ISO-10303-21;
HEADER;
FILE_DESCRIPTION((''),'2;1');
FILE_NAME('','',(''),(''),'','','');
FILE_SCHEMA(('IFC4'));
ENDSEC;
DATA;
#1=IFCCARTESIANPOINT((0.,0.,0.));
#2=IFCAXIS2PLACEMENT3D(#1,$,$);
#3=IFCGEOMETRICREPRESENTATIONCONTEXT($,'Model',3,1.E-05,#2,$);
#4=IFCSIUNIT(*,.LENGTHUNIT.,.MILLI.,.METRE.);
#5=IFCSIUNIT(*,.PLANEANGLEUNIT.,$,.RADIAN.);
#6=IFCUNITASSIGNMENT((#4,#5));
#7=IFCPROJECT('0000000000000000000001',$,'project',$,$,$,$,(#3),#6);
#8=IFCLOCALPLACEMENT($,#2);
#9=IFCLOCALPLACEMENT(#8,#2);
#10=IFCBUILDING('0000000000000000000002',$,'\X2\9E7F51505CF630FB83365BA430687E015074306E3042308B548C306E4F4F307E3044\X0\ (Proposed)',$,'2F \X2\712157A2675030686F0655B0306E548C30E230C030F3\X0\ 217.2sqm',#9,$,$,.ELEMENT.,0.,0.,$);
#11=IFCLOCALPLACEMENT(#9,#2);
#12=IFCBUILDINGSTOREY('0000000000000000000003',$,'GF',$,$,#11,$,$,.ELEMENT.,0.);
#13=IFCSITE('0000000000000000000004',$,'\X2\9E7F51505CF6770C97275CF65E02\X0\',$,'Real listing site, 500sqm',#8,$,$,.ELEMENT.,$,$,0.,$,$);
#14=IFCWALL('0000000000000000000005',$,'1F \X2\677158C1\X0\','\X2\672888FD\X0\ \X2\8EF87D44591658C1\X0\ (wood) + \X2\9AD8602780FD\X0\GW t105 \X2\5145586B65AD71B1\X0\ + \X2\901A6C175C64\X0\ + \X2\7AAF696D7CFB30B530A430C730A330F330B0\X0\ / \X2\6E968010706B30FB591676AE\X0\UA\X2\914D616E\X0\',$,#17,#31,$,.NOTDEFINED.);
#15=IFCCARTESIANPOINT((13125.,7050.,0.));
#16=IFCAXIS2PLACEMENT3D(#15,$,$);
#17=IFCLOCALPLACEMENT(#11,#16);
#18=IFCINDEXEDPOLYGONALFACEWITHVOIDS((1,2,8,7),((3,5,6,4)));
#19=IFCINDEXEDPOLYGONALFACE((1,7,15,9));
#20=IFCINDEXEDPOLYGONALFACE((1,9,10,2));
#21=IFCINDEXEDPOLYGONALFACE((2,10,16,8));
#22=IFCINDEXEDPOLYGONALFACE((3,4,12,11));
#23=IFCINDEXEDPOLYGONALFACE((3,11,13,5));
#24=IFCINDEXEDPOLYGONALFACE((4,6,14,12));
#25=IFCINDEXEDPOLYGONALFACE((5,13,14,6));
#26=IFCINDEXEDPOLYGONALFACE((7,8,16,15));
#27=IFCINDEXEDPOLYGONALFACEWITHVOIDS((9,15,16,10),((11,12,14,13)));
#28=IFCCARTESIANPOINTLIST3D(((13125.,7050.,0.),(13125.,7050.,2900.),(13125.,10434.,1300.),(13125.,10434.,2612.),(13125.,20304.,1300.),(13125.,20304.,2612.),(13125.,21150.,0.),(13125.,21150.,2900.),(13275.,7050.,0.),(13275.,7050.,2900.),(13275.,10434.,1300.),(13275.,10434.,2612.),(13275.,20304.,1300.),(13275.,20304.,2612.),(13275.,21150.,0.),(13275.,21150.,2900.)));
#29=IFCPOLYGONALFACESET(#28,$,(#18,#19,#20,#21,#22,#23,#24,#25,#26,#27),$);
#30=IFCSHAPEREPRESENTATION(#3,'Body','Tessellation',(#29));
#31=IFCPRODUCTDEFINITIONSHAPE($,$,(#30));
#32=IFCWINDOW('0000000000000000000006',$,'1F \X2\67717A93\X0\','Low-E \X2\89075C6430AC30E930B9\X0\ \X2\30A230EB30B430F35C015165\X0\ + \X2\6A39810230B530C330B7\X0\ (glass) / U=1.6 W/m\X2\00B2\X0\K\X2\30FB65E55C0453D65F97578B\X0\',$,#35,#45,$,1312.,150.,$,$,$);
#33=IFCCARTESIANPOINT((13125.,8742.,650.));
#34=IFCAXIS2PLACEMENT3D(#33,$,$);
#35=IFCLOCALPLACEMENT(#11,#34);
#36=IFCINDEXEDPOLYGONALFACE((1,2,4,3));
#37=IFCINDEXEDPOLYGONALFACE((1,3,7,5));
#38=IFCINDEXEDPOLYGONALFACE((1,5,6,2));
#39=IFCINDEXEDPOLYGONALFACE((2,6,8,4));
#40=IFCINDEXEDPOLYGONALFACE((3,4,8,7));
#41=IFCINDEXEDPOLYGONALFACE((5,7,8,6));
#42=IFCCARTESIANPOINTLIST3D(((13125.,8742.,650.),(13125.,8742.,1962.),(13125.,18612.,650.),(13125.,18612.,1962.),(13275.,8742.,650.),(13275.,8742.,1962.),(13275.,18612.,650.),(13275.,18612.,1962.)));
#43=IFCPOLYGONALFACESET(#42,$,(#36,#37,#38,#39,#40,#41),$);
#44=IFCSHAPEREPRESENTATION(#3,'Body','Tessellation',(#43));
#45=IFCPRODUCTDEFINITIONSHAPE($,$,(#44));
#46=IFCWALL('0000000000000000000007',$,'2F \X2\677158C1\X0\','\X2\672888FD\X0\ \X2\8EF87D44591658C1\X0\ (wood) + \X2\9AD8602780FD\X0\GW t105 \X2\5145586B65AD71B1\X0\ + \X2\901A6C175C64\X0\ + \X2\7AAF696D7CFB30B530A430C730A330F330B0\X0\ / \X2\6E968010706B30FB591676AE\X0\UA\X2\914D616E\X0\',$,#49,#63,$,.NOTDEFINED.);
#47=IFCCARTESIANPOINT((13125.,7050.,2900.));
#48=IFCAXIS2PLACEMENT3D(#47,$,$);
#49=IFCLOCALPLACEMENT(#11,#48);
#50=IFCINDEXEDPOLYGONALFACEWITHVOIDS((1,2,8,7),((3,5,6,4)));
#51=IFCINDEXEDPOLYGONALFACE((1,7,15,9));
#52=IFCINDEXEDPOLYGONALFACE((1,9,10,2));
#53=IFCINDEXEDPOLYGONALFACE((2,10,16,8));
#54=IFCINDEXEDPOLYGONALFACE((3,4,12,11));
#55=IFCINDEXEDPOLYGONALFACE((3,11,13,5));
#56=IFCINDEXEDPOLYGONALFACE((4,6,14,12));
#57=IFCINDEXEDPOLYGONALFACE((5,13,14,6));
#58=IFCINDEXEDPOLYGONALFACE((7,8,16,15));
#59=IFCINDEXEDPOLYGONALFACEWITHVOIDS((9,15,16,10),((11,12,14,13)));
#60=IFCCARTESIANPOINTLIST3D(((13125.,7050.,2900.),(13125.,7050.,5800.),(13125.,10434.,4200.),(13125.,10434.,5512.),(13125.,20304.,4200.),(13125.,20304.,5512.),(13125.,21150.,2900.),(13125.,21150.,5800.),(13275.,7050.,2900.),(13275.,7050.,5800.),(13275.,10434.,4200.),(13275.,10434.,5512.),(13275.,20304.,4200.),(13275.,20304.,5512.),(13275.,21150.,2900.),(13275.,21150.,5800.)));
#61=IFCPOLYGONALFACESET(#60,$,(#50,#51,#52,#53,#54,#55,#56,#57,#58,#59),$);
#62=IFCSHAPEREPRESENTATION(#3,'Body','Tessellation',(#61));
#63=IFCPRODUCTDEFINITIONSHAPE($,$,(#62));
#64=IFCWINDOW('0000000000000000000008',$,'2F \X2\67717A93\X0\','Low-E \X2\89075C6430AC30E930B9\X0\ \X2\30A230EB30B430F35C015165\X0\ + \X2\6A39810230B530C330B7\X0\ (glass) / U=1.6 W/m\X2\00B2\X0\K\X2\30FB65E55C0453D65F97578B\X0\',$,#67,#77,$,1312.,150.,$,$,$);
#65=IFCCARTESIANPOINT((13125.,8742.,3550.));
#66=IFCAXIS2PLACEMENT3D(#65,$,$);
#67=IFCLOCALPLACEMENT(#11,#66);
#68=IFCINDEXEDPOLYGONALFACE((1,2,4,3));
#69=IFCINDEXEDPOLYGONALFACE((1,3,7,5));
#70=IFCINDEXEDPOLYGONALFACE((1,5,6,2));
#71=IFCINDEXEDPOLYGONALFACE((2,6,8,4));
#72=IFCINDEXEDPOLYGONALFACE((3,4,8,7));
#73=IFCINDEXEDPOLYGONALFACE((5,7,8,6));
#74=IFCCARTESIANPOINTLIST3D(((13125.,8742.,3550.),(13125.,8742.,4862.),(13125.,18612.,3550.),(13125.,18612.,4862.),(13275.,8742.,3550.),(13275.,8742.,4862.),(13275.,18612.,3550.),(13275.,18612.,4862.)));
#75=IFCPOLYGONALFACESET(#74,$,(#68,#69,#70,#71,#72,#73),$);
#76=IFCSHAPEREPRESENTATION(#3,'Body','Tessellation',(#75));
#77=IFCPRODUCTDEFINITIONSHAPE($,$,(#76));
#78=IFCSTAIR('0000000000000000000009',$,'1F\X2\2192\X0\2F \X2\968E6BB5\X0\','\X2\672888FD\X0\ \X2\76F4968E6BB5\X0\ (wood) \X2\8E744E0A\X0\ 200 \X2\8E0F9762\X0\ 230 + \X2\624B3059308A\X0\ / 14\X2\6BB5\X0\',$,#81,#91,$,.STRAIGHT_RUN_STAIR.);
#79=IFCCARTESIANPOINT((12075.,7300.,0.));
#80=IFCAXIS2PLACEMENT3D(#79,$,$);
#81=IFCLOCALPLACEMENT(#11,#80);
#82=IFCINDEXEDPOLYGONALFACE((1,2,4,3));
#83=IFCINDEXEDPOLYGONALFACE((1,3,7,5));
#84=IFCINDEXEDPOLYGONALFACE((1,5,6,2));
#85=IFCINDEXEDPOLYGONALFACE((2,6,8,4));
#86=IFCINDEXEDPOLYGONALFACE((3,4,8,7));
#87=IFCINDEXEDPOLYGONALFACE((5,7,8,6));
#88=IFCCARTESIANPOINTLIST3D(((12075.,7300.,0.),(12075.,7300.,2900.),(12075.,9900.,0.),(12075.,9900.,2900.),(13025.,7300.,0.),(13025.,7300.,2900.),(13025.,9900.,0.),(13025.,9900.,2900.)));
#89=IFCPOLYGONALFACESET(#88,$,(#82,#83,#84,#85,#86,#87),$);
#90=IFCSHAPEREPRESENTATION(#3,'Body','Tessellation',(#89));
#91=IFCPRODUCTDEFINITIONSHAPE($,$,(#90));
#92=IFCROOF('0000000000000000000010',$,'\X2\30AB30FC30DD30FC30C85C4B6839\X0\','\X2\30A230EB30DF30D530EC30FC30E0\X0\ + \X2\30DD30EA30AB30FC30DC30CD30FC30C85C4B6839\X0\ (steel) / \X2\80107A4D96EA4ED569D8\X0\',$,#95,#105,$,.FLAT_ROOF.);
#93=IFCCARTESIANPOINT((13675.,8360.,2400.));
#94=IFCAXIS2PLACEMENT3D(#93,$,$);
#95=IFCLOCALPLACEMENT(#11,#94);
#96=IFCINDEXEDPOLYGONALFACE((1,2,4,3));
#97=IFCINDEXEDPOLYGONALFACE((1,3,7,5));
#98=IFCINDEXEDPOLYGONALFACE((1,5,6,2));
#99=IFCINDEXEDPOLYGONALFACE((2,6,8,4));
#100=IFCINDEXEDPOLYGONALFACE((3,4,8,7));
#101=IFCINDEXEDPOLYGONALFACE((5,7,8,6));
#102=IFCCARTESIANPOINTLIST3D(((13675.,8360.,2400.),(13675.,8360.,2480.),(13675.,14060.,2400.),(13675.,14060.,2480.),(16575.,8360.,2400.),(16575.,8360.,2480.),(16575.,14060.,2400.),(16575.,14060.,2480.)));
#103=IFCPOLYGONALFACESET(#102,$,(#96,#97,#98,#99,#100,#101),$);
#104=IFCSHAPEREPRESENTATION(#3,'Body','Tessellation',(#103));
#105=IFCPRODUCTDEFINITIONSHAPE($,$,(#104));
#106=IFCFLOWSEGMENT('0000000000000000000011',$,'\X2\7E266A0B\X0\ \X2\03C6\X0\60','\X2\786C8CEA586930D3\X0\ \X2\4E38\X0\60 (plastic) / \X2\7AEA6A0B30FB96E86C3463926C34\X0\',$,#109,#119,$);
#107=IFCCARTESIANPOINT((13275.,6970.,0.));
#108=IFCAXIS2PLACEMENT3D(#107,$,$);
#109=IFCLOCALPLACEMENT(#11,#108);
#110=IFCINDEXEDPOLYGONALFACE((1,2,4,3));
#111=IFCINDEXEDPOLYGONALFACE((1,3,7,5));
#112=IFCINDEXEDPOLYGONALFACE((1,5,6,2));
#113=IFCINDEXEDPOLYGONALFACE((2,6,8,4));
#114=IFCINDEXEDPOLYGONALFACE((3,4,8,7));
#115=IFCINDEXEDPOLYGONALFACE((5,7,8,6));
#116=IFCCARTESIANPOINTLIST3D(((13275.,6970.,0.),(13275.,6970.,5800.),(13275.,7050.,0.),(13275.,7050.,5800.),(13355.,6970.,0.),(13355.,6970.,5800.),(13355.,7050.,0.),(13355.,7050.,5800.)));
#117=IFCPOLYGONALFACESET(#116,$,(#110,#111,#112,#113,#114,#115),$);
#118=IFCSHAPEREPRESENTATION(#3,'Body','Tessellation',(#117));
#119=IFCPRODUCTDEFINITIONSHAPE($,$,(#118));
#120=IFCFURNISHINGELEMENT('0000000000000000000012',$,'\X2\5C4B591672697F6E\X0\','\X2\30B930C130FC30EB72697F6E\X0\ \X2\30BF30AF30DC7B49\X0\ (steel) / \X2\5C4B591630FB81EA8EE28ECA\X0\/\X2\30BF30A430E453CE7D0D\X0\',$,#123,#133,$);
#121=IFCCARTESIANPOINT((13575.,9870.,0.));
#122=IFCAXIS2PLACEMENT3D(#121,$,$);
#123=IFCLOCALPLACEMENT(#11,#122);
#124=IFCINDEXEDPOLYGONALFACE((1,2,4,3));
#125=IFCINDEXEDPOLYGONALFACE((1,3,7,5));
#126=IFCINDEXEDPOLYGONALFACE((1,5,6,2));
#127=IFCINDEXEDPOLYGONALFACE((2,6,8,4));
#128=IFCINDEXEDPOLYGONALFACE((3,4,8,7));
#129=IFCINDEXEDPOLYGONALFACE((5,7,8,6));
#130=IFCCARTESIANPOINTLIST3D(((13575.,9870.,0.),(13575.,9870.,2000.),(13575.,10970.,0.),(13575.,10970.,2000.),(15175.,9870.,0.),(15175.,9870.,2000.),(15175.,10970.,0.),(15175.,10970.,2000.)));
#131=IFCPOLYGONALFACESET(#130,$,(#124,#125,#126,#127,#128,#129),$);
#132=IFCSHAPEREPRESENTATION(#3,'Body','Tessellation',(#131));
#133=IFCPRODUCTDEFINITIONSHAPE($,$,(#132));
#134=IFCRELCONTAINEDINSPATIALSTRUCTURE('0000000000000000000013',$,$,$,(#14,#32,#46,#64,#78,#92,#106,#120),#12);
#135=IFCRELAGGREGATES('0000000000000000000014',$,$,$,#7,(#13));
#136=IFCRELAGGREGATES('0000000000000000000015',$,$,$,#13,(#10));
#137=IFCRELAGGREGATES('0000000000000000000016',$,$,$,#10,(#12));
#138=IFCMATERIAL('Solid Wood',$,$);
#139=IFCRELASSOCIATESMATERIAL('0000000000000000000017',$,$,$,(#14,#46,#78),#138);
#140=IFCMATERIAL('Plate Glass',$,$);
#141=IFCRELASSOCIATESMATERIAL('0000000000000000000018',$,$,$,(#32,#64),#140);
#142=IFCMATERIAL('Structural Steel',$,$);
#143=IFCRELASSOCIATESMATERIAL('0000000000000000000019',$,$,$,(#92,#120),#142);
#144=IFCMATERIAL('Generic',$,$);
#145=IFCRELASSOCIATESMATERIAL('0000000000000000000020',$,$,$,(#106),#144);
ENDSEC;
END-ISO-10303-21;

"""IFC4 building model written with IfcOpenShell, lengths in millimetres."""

from ifc_helpers import new_model, si_unit, frame, frame_2d, origin, place, context, project, spatial, rectangle, extrude, material, element, fill, save


model = new_model("IFC4")

# Units and contexts
model_context = context("Model", 3, precision=1e-05, world=origin())
ifc_project = project(units=[si_unit("LENGTHUNIT", "METRE", prefix="MILLI"), si_unit("PLANEANGLEUNIT", "RADIAN")], contexts=[model_context])

# Site, building, storey
site_placement = place(None, origin())
site = spatial("IfcSite", under=ifc_project, at=site_placement, Name="鹿児島県霧島市", ObjectType="Real listing site, 500sqm", CompositionType="ELEMENT", RefElevation=0.0)
building_placement = place(site_placement, origin())
building = spatial("IfcBuilding", under=site, at=building_placement, Name="鹿児島・茶室と縁側のある和の住まい (Proposed)", ObjectType="2F 無垢材と漆喰の和モダン 217.2sqm", CompositionType="ELEMENT", ElevationOfRefHeight=0.0, ElevationOfTerrain=0.0)
storey_placement = place(building_placement, origin())
storey = spatial("IfcBuildingStorey", under=building, at=storey_placement, Name="GF", CompositionType="ELEMENT", Elevation=0.0)

# Shared definitions
ifc_material_1 = material(Name="Solid Wood")
ifc_material_2 = material(Name="Structural Steel")

# Walls, openings, windows
wall_1_placement = place(storey_placement, frame((13125.0, 7050.0, 0.0)))
wall_1 = element("IfcWall", 1, at=wall_1_placement, inside=storey, material=ifc_material_1, Name="1F 東壁", Description="木製 軸組外壁 (wood) + 高性能GW t105 充填断熱 + 通気層 + 窯業系サイディング / 準耐火・外皮UA配慮", PredefinedType="NOTDEFINED", context=model_context, shape_type="SweptSolid", body=[
    extrude(rectangle(XDim=150.0, YDim=14100.0, at=frame_2d((75.0, 7050.0))), frame((13125.0, 7050.0, 0.0)), (0.0, 0.0, 1.0), 2900.0),
])
opening_1_placement = place(storey_placement, frame((13125.0, 8742.0, 650.0)))
opening_1 = element("IfcOpeningElement", 2, at=opening_1_placement, cuts=wall_1, PredefinedType="NOTDEFINED", context=model_context, shape_type="SweptSolid", body=[
    extrude(rectangle(XDim=150.0, YDim=9870.0, at=frame_2d((75.0, 4935.0))), frame((13125.0, 8742.0, 650.0)), (0.0, 0.0, 1.0), 1312.0),
])
ifc_material_3 = material(Name="Plate Glass")
window_1_placement = place(storey_placement, frame((13125.0, 8742.0, 650.0)))
window_1 = element("IfcWindow", 3, at=window_1_placement, inside=storey, material=ifc_material_3, Name="1F 東窓", Description="Low-E 複層ガラス アルゴン封入 + 樹脂サッシ (glass) / U=1.6 W/m²K・日射取得型", OverallHeight=1312.0, OverallWidth=150.0, context=model_context, shape_type="SweptSolid", body=[
    extrude(rectangle(XDim=150.0, YDim=9870.0, at=frame_2d((75.0, 4935.0))), frame((13125.0, 8742.0, 650.0)), (0.0, 0.0, 1.0), 1312.0),
])
fill(opening_1, window_1)
wall_2_placement = place(storey_placement, frame((13125.0, 7050.0, 2900.0)))
wall_2 = element("IfcWall", 4, at=wall_2_placement, inside=storey, material=ifc_material_1, Name="2F 東壁", Description="木製 軸組外壁 (wood) + 高性能GW t105 充填断熱 + 通気層 + 窯業系サイディング / 準耐火・外皮UA配慮", PredefinedType="NOTDEFINED", context=model_context, shape_type="SweptSolid", body=[
    extrude(rectangle(XDim=150.0, YDim=14100.0, at=frame_2d((75.0, 7050.0))), frame((13125.0, 7050.0, 2900.0)), (0.0, 0.0, 1.0), 2900.0),
])
opening_2_placement = place(storey_placement, frame((13125.0, 8742.0, 3550.0)))
opening_2 = element("IfcOpeningElement", 5, at=opening_2_placement, cuts=wall_2, PredefinedType="NOTDEFINED", context=model_context, shape_type="SweptSolid", body=[
    extrude(rectangle(XDim=150.0, YDim=9870.0, at=frame_2d((75.0, 4935.0))), frame((13125.0, 8742.0, 3550.0)), (0.0, 0.0, 1.0), 1312.0),
])
window_2_placement = place(storey_placement, frame((13125.0, 8742.0, 3550.0)))
window_2 = element("IfcWindow", 6, at=window_2_placement, inside=storey, material=ifc_material_3, Name="2F 東窓", Description="Low-E 複層ガラス アルゴン封入 + 樹脂サッシ (glass) / U=1.6 W/m²K・日射取得型", OverallHeight=1312.0, OverallWidth=150.0, context=model_context, shape_type="SweptSolid", body=[
    extrude(rectangle(XDim=150.0, YDim=9870.0, at=frame_2d((75.0, 4935.0))), frame((13125.0, 8742.0, 3550.0)), (0.0, 0.0, 1.0), 1312.0),
])
fill(opening_2, window_2)

# Stair
stair_placement = place(storey_placement, frame((12075.0, 7300.0, 0.0)))
element("IfcStair", 7, at=stair_placement, inside=storey, material=ifc_material_1, Name="1F→2F 階段", Description="木製 直階段 (wood) 蹴上 200 踏面 230 + 手すり / 14段", PredefinedType="STRAIGHT_RUN_STAIR", context=model_context, shape_type="SweptSolid", body=[
    extrude(rectangle(XDim=950.0, YDim=2600.0, at=frame_2d((475.0, 1300.0))), frame((12075.0, 7300.0, 0.0)), (0.0, 0.0, 1.0), 2900.0),
])

# Roof
roof_placement = place(storey_placement, frame((13675.0, 8360.0, 2400.0)))
element("IfcRoof", 8, at=roof_placement, inside=storey, material=ifc_material_2, Name="カーポート屋根", Description="アルミフレーム + ポリカーボネート屋根 (steel) / 耐積雪仕様", PredefinedType="FLAT_ROOF", context=model_context, shape_type="SweptSolid", body=[
    extrude(rectangle(XDim=2900.0, YDim=5700.0, at=frame_2d((1450.0, 2850.0))), frame((13675.0, 8360.0, 2400.0)), (0.0, 0.0, 1.0), 80.0),
])

# Flow segment
ifc_material_4 = material(Name="Generic")
flow_segment_placement = place(storey_placement, frame((13275.0, 6970.0, 0.0)))
element("IfcFlowSegment", 9, at=flow_segment_placement, inside=storey, material=ifc_material_4, Name="縦樋 φ60", Description="硬質塩ビ 丸60 (plastic) / 竪樋・雨水排水", context=model_context, shape_type="SweptSolid", body=[
    extrude(rectangle(XDim=80.0, YDim=80.0, at=frame_2d((40.0, 40.0))), frame((13275.0, 6970.0, 0.0)), (0.0, 0.0, 1.0), 5800.0),
])

# Furnishing element
furnishing_placement = place(storey_placement, frame((13575.0, 9870.0, 0.0)))
element("IfcFurnishingElement", 10, at=furnishing_placement, inside=storey, material=ifc_material_2, Name="屋外物置", Description="スチール物置 タクボ等 (steel) / 屋外・自転車/タイヤ収納", context=model_context, shape_type="SweptSolid", body=[
    extrude(rectangle(XDim=1600.0, YDim=1100.0, at=frame_2d((800.0, 550.0))), frame((13575.0, 9870.0, 0.0)), (0.0, 0.0, 1.0), 2000.0),
])

save(model, "model.ifc")
